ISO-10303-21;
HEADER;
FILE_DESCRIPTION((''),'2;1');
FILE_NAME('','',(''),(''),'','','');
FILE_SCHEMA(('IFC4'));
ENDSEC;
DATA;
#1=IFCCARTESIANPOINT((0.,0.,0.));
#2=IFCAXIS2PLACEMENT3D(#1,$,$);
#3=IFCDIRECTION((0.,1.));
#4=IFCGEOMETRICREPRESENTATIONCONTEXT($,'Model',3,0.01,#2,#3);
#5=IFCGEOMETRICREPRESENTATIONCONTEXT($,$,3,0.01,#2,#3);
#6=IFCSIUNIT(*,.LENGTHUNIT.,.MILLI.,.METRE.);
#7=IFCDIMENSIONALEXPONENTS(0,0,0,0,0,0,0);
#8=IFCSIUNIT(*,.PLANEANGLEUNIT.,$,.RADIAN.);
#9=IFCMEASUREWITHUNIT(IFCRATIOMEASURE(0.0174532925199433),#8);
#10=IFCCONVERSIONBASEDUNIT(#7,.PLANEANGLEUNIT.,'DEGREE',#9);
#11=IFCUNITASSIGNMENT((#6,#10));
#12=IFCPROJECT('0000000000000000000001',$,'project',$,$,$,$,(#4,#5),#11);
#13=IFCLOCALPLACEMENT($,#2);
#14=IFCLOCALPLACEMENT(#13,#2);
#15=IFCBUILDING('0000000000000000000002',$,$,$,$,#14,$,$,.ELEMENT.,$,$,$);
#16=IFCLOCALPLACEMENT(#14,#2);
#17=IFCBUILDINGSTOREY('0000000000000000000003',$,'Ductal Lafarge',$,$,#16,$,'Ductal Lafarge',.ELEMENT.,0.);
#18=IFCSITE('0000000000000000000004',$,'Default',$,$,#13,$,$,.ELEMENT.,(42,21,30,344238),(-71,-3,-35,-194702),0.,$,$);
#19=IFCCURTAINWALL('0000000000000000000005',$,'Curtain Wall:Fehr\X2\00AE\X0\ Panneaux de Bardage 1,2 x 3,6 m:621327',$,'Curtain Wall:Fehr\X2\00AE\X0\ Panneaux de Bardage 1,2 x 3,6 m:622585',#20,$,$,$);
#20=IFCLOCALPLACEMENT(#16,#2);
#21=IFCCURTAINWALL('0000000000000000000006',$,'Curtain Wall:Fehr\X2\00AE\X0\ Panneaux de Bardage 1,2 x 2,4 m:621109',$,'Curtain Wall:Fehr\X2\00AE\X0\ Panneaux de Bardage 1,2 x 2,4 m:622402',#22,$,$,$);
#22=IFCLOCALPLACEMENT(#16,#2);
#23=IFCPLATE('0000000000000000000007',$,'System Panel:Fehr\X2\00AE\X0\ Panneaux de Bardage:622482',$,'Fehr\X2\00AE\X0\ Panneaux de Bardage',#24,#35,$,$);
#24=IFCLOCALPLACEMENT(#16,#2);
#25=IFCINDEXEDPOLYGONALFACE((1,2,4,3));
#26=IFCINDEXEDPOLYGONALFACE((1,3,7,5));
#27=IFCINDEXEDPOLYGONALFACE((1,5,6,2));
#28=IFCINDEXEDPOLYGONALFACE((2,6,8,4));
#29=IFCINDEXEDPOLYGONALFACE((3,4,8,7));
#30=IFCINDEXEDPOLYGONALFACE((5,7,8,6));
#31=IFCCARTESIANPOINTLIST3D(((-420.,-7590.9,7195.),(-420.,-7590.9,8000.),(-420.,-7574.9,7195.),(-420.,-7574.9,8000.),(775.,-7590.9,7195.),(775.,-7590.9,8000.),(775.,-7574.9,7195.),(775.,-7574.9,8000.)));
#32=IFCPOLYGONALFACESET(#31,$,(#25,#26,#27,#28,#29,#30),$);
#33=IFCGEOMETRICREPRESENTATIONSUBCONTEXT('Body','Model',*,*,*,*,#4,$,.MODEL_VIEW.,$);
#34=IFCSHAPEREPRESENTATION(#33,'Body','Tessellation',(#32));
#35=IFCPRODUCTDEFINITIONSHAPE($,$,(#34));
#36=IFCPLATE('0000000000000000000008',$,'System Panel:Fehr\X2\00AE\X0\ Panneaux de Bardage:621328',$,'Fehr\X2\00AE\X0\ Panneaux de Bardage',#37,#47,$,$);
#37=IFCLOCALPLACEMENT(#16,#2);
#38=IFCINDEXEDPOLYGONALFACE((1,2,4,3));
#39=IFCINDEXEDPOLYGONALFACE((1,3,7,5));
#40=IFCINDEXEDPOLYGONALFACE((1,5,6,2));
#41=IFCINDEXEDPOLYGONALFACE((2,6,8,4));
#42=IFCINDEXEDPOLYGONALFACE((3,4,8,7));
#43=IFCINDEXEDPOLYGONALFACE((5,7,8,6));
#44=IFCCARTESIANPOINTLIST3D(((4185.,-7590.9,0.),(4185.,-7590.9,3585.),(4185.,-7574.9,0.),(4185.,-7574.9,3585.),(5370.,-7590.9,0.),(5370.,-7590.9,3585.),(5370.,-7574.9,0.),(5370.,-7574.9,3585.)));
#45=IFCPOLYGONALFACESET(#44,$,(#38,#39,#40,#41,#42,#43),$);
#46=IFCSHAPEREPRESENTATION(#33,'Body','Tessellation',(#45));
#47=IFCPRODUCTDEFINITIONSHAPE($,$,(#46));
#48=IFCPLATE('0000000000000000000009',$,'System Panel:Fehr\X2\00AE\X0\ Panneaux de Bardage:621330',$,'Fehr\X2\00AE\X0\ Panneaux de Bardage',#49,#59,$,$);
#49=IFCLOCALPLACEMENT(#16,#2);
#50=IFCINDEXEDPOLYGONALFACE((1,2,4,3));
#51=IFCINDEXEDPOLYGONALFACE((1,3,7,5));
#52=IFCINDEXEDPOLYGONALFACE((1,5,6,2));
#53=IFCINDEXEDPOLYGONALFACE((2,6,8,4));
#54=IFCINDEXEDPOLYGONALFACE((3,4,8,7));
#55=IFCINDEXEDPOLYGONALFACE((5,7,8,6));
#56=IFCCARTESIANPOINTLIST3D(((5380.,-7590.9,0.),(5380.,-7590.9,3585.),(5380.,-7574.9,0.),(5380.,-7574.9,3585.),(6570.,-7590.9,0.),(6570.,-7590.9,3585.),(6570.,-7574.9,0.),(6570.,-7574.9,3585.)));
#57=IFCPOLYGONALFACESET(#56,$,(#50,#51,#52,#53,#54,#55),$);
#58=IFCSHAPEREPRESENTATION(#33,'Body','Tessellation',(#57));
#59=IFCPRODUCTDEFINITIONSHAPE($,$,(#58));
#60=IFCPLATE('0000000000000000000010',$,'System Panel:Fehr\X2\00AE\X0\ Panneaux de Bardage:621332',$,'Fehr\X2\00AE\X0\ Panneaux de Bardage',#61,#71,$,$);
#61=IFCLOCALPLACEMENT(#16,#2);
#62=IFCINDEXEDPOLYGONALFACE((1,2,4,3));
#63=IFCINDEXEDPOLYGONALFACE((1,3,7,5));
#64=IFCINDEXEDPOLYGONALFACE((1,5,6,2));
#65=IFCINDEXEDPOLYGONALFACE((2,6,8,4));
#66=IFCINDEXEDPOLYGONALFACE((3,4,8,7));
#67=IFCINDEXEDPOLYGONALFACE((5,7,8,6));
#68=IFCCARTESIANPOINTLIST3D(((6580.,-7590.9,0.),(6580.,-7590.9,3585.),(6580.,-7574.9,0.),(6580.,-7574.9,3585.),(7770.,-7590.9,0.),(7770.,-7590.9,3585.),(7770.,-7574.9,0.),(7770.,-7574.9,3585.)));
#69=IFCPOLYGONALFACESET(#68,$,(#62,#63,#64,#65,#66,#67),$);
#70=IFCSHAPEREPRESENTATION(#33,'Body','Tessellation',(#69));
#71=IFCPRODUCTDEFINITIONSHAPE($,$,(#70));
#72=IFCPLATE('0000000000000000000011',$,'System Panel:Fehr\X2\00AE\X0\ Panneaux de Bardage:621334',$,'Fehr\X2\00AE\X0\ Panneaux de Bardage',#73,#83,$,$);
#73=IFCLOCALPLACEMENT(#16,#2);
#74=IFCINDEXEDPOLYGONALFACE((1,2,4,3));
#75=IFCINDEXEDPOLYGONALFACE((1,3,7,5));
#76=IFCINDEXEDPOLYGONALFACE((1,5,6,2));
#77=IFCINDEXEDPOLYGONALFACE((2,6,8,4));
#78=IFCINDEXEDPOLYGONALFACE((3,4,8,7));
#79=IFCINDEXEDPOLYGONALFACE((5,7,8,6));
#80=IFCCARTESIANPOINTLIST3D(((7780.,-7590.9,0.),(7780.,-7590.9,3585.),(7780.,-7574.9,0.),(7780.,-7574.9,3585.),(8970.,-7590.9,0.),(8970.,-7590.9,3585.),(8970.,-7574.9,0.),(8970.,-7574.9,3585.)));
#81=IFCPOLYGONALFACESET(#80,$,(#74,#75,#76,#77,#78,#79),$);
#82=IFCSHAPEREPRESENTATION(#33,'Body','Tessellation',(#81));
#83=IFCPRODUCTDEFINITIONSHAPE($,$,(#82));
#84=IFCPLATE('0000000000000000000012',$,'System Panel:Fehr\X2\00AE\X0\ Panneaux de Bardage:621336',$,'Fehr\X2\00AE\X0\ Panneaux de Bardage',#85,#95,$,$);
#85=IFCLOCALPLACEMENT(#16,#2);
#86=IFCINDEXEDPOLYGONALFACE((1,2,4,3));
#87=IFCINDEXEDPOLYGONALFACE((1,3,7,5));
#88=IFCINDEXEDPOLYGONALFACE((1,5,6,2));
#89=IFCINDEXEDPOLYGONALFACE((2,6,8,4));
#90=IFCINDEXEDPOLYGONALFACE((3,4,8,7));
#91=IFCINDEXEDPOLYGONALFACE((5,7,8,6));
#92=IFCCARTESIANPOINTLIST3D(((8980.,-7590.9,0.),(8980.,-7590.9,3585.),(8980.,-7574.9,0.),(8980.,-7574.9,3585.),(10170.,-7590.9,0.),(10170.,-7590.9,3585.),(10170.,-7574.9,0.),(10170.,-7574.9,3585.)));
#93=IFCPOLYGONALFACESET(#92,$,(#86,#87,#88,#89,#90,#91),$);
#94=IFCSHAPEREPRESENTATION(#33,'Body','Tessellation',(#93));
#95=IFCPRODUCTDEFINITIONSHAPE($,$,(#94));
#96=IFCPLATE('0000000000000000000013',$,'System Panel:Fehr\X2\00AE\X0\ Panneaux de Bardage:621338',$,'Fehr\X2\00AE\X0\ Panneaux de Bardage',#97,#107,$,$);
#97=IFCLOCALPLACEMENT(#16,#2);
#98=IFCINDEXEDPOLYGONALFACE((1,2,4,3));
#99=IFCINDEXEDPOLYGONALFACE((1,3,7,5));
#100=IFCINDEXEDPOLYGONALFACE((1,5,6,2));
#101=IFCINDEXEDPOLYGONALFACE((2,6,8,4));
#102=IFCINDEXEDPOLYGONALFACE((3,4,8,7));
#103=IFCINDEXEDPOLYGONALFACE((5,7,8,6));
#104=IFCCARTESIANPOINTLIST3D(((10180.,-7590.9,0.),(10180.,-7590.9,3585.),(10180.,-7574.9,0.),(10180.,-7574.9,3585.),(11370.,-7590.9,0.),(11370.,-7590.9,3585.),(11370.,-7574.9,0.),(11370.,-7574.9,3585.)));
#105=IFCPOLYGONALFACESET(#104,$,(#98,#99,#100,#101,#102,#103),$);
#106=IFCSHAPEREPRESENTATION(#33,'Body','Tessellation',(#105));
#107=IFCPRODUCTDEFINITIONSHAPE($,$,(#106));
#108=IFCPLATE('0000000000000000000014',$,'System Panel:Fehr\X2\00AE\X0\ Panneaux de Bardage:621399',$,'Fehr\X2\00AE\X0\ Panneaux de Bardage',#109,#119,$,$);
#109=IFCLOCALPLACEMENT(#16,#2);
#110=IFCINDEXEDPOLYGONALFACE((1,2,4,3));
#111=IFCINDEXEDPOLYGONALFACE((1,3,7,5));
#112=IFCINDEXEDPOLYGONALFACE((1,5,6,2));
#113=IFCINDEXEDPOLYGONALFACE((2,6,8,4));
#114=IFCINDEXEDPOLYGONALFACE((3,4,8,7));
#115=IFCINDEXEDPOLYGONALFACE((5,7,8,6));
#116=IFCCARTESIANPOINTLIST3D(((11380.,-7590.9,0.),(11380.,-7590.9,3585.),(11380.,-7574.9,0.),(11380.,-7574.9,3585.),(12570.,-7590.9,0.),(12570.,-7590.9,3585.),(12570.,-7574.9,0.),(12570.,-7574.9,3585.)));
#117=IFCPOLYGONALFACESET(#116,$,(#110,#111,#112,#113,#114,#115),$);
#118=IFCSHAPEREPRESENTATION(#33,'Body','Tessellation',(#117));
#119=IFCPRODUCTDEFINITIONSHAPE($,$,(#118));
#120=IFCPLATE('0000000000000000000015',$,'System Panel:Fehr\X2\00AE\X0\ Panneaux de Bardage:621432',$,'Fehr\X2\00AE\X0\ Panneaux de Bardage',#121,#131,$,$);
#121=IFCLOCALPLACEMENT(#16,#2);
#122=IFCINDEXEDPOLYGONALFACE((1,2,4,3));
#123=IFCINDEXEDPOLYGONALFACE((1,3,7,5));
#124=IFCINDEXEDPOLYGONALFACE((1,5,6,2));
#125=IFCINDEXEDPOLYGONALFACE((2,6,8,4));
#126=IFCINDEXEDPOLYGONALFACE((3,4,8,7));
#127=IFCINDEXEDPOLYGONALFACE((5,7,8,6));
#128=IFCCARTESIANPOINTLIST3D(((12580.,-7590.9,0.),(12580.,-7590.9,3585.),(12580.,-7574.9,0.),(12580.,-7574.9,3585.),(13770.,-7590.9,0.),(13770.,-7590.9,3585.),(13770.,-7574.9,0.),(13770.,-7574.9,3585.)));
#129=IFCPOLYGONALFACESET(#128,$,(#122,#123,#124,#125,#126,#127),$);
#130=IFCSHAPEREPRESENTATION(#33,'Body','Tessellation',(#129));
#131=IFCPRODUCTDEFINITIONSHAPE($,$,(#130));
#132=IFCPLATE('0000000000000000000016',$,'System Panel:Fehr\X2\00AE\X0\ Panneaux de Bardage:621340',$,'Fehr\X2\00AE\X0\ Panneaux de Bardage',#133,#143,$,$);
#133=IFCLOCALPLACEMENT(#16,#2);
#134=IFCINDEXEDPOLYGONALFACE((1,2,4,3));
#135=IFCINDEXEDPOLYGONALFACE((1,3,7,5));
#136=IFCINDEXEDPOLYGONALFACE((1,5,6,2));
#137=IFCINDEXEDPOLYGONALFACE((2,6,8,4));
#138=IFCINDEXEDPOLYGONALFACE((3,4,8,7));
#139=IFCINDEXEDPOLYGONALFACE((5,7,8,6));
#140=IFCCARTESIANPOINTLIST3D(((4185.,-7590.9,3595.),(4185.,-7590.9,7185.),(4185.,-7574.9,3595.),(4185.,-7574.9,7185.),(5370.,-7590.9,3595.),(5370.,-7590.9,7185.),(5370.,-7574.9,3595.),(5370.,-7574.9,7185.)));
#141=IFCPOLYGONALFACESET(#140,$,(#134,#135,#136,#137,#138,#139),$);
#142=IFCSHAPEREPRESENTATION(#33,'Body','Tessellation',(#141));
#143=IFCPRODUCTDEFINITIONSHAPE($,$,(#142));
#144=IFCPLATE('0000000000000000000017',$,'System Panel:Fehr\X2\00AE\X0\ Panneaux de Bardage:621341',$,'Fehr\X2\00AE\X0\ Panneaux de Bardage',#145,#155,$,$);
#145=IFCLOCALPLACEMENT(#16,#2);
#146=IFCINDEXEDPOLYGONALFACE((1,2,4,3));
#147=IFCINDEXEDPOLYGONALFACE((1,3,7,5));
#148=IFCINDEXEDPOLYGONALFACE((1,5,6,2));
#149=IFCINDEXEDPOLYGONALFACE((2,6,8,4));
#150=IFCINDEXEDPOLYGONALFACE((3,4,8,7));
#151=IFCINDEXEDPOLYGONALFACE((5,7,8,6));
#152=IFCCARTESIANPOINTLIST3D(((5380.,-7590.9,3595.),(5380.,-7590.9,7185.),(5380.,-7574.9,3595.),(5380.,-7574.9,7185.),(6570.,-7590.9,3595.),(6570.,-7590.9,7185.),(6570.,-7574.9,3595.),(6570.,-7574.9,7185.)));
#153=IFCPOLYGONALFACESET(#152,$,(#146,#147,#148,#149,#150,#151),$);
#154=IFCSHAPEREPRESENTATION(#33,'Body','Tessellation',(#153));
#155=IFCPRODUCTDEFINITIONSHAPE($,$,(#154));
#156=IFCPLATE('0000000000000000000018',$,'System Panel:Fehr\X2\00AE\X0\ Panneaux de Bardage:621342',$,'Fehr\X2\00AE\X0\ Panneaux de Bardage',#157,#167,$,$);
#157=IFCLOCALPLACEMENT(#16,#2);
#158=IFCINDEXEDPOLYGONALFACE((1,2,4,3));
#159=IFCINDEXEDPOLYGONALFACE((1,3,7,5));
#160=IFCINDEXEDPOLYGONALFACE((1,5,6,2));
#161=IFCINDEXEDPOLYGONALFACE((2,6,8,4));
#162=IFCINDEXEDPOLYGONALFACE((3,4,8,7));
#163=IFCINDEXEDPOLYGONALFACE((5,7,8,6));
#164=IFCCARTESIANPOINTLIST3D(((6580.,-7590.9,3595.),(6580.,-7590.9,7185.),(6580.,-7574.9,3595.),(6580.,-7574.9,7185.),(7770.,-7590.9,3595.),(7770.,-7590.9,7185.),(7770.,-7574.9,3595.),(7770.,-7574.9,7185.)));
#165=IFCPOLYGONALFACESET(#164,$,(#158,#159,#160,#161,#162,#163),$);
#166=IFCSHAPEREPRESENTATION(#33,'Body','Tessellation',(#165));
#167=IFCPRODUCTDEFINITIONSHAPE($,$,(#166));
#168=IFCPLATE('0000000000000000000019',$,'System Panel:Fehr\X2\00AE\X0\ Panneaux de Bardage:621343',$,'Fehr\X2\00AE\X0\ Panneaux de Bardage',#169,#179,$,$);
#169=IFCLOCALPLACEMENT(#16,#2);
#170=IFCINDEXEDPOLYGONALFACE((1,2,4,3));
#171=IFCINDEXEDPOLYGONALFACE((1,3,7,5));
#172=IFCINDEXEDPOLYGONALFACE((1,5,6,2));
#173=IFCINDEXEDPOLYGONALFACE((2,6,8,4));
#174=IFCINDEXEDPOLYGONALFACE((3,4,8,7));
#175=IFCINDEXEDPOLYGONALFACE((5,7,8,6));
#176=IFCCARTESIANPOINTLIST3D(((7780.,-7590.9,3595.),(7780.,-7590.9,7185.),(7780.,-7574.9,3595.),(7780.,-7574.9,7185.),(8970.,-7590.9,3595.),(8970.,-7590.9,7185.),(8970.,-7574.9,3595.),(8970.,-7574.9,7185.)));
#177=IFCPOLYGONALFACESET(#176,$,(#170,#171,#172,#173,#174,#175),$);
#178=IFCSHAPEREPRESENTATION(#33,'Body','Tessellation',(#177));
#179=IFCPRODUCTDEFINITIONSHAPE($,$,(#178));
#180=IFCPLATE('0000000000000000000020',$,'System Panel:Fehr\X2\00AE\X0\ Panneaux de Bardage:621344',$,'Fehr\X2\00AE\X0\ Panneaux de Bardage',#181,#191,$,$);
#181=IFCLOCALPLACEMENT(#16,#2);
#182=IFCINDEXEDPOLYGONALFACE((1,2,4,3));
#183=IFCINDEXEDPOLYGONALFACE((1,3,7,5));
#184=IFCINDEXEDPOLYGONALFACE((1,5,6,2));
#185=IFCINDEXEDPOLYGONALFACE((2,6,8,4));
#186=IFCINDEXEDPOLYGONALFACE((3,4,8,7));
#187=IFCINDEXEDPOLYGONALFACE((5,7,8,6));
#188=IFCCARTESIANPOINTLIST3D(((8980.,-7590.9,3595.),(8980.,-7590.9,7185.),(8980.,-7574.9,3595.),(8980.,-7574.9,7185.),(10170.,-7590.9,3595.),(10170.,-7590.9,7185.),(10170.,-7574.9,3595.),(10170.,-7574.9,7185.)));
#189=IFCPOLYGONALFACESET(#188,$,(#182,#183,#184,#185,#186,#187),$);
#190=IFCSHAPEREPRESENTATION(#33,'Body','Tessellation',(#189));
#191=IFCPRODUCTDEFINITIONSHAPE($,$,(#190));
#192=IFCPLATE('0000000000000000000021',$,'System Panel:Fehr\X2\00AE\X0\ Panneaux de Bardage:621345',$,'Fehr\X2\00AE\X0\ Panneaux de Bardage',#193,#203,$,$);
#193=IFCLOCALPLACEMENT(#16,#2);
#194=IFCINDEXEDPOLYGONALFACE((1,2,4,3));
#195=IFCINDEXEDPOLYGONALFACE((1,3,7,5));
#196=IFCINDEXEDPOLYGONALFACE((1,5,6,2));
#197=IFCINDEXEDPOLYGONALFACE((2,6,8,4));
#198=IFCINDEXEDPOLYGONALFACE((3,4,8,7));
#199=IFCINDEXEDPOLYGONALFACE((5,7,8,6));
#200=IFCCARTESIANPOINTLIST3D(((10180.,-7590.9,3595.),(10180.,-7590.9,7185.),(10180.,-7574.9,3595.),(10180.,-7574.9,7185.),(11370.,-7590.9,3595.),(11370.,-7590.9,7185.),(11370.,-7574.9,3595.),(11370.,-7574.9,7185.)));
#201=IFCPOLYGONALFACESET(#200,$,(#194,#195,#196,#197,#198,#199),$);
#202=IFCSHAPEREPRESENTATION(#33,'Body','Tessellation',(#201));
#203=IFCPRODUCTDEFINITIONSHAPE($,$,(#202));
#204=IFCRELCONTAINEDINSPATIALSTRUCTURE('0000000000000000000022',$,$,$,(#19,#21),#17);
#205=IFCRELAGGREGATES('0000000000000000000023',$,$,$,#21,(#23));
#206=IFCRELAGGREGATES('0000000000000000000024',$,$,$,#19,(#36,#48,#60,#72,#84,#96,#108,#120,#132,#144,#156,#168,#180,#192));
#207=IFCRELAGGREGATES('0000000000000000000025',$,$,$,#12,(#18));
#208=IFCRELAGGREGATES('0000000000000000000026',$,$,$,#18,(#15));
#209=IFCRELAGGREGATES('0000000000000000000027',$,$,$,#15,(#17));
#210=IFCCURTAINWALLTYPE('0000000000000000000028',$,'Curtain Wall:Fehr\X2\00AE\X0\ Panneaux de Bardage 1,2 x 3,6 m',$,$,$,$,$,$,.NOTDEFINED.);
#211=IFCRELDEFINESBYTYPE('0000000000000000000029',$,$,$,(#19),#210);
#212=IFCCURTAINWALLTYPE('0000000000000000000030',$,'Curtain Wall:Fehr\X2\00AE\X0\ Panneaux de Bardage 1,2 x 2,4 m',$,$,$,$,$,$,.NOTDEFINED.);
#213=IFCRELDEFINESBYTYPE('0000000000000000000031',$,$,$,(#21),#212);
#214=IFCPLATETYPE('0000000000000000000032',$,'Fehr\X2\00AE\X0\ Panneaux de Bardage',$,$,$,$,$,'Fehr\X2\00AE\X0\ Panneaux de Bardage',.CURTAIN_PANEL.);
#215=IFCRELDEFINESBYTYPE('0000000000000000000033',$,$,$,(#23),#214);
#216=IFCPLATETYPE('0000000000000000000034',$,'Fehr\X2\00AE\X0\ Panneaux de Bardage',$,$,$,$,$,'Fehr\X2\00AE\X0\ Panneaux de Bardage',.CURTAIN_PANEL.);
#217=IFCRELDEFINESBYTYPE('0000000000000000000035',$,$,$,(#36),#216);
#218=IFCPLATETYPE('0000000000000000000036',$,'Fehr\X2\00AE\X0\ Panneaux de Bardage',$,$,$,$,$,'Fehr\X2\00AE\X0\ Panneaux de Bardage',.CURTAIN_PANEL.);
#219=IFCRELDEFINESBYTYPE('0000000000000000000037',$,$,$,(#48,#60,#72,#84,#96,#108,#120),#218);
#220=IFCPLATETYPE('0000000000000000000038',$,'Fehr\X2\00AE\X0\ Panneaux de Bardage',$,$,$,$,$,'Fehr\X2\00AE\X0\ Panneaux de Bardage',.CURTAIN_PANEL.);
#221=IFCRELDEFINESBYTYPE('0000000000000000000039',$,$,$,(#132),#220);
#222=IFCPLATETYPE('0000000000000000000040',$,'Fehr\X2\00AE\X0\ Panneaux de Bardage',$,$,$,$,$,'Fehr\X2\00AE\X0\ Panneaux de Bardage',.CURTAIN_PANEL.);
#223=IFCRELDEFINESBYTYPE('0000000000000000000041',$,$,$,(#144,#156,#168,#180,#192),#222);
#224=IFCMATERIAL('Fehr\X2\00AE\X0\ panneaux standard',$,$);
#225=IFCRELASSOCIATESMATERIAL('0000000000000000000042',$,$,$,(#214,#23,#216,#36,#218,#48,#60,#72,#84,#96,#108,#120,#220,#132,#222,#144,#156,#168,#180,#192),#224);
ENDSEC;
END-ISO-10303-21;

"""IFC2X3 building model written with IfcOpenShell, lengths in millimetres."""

from ifc_helpers import new_model, entity, si_unit, converted_unit, direction, frame, origin, origin_2d_with_axis, place, context, subcontext, project, spatial, rectangle, extrude, source, transform, mapped, material, type_object, type_shapes, element, aggregate, save


model = new_model("IFC2X3")

# Units and contexts
model_context = context("Model", 3, precision=0.01, world=origin(), true_north=direction((0.0, 1.0)))
context_of_model = context(None, 3, precision=0.01, world=origin(), true_north=direction((0.0, 1.0)))
body_context = subcontext(model_context, "Body", "Model", "MODEL_VIEW")
ifc_project = project(units=[si_unit("LENGTHUNIT", "METRE", prefix="MILLI"), converted_unit("PLANEANGLEUNIT", "DEGREE", entity("IfcRatioMeasure", 0.0174532925199433), si_unit("PLANEANGLEUNIT", "RADIAN"), dimensions=[0, 0, 0, 0, 0, 0, 0])], contexts=[model_context, context_of_model])

# Site, building, storey
site_placement = place(None, origin())
site = spatial("IfcSite", under=ifc_project, at=site_placement, Name="Default", CompositionType="ELEMENT", RefLatitude=(42, 21, 30, 344238), RefLongitude=(-71, -3, -35, -194702), RefElevation=0.0)
building_placement = place(site_placement, origin())
building = spatial("IfcBuilding", under=site, at=building_placement, CompositionType="ELEMENT")
storey_placement = place(building_placement, origin())
storey = spatial("IfcBuildingStorey", under=building, at=storey_placement, Name="Ductal Lafarge", LongName="Ductal Lafarge", CompositionType="ELEMENT", Elevation=0.0)

# Curtain wall
curtain_wall_type_1 = type_object("IfcCurtainWallType", Name="Curtain Wall:Fehr® Panneaux de Bardage 1,2 x 3,6 m", PredefinedType="NOTDEFINED")
curtain_wall_1_placement = place(storey_placement, origin())
curtain_wall_1 = element("IfcCurtainWall", 1, at=curtain_wall_1_placement, inside=storey, type_object=curtain_wall_type_1, Name="Curtain Wall:Fehr® Panneaux de Bardage 1,2 x 3,6 m:621327", ObjectType="Curtain Wall:Fehr® Panneaux de Bardage 1,2 x 3,6 m:622585")
ifc_material_1 = material(Name="Fehr® panneaux standard")

# Curtain wall, plate
curtain_wall_type_2 = type_object("IfcCurtainWallType", Name="Curtain Wall:Fehr® Panneaux de Bardage 1,2 x 2,4 m", PredefinedType="NOTDEFINED")
curtain_wall_2_placement = place(storey_placement, origin())
curtain_wall_2 = element("IfcCurtainWall", 2, at=curtain_wall_2_placement, inside=storey, type_object=curtain_wall_type_2, Name="Curtain Wall:Fehr® Panneaux de Bardage 1,2 x 2,4 m:621109", ObjectType="Curtain Wall:Fehr® Panneaux de Bardage 1,2 x 2,4 m:622402")
plate_type_1 = type_object("IfcPlateType", Name="Fehr® Panneaux de Bardage", ElementType="Fehr® Panneaux de Bardage", PredefinedType="CURTAIN_PANEL", material=ifc_material_1)
shared_shape_1 = source(origin(), body_context, "Body", "SweptSolid", [
    extrude(rectangle(XDim=16.0, YDim=1195.0, at=origin_2d_with_axis()), frame((0.0, 0.0, 0.0), z_axis=(0.0, 0.0, 1.0), x_axis=(0.0, 1.0, 0.0)), (0.0, 0.0, 1.0), 805.0),
])
type_shapes(plate_type_1, [shared_shape_1])
plate_1_placement = place(curtain_wall_2_placement, frame((177.5, -7582.9, 7195.0)))
plate_1 = element("IfcPlate", 3, at=plate_1_placement, type_object=plate_type_1, material=ifc_material_1, Name="System Panel:Fehr® Panneaux de Bardage:622482", ObjectType="Fehr® Panneaux de Bardage", context=body_context, shape_type="MappedRepresentation", body=[
    mapped(shared_shape_1, transform((0.0, 0.0, 0.0), scale=1.0)),
])
aggregate(curtain_wall_2, [plate_1])

# Plates
plate_type_2 = type_object("IfcPlateType", Name="Fehr® Panneaux de Bardage", ElementType="Fehr® Panneaux de Bardage", PredefinedType="CURTAIN_PANEL", material=ifc_material_1)
shared_shape_2 = source(origin(), body_context, "Body", "SweptSolid", [
    extrude(rectangle(XDim=16.0, YDim=1185.0, at=origin_2d_with_axis()), frame((0.0, 0.0, 0.0), z_axis=(0.0, 0.0, 1.0), x_axis=(0.0, 1.0, 0.0)), (0.0, 0.0, 1.0), 3585.0),
])
type_shapes(plate_type_2, [shared_shape_2])
plate_2_placement = place(curtain_wall_1_placement, frame((4777.5, -7582.9, 0.0)))
plate_2 = element("IfcPlate", 4, at=plate_2_placement, type_object=plate_type_2, material=ifc_material_1, Name="System Panel:Fehr® Panneaux de Bardage:621328", ObjectType="Fehr® Panneaux de Bardage", context=body_context, shape_type="MappedRepresentation", body=[
    mapped(shared_shape_2, transform((0.0, 0.0, 0.0), scale=1.0)),
])
plate_type_3 = type_object("IfcPlateType", Name="Fehr® Panneaux de Bardage", ElementType="Fehr® Panneaux de Bardage", PredefinedType="CURTAIN_PANEL", material=ifc_material_1)
shared_shape_3 = source(origin(), body_context, "Body", "SweptSolid", [
    extrude(rectangle(XDim=16.0, YDim=1190.0, at=origin_2d_with_axis()), frame((0.0, 0.0, 0.0), z_axis=(0.0, 0.0, 1.0), x_axis=(0.0, 1.0, 0.0)), (0.0, 0.0, 1.0), 3585.0),
])
type_shapes(plate_type_3, [shared_shape_3])
plate_3_placement = place(curtain_wall_1_placement, frame((5975.0, -7582.9, 0.0)))
plate_3 = element("IfcPlate", 5, at=plate_3_placement, type_object=plate_type_3, material=ifc_material_1, Name="System Panel:Fehr® Panneaux de Bardage:621330", ObjectType="Fehr® Panneaux de Bardage", context=body_context, shape_type="MappedRepresentation", body=[
    mapped(shared_shape_3, transform((0.0, 0.0, 0.0), scale=1.0)),
])
plate_4_placement = place(curtain_wall_1_placement, frame((7175.0, -7582.9, 0.0)))
plate_4 = element("IfcPlate", 6, at=plate_4_placement, type_object=plate_type_3, material=ifc_material_1, Name="System Panel:Fehr® Panneaux de Bardage:621332", ObjectType="Fehr® Panneaux de Bardage", context=body_context, shape_type="MappedRepresentation", body=[
    mapped(shared_shape_3, transform((0.0, 0.0, 0.0), scale=1.0)),
])
plate_5_placement = place(curtain_wall_1_placement, frame((8375.0, -7582.9, 0.0)))
plate_5 = element("IfcPlate", 7, at=plate_5_placement, type_object=plate_type_3, material=ifc_material_1, Name="System Panel:Fehr® Panneaux de Bardage:621334", ObjectType="Fehr® Panneaux de Bardage", context=body_context, shape_type="MappedRepresentation", body=[
    mapped(shared_shape_3, transform((0.0, 0.0, 0.0), scale=1.0)),
])
plate_6_placement = place(curtain_wall_1_placement, frame((9575.0, -7582.9, 0.0)))
plate_6 = element("IfcPlate", 8, at=plate_6_placement, type_object=plate_type_3, material=ifc_material_1, Name="System Panel:Fehr® Panneaux de Bardage:621336", ObjectType="Fehr® Panneaux de Bardage", context=body_context, shape_type="MappedRepresentation", body=[
    mapped(shared_shape_3, transform((0.0, 0.0, 0.0), scale=1.0)),
])
plate_7_placement = place(curtain_wall_1_placement, frame((10775.0, -7582.9, 0.0)))
plate_7 = element("IfcPlate", 9, at=plate_7_placement, type_object=plate_type_3, material=ifc_material_1, Name="System Panel:Fehr® Panneaux de Bardage:621338", ObjectType="Fehr® Panneaux de Bardage", context=body_context, shape_type="MappedRepresentation", body=[
    mapped(shared_shape_3, transform((0.0, 0.0, 0.0), scale=1.0)),
])
plate_8_placement = place(curtain_wall_1_placement, frame((11975.0, -7582.9, 0.0)))
plate_8 = element("IfcPlate", 10, at=plate_8_placement, type_object=plate_type_3, material=ifc_material_1, Name="System Panel:Fehr® Panneaux de Bardage:621399", ObjectType="Fehr® Panneaux de Bardage", context=body_context, shape_type="MappedRepresentation", body=[
    mapped(shared_shape_3, transform((0.0, 0.0, 0.0), scale=1.0)),
])
plate_9_placement = place(curtain_wall_1_placement, frame((13175.0, -7582.9, 0.0)))
plate_9 = element("IfcPlate", 11, at=plate_9_placement, type_object=plate_type_3, material=ifc_material_1, Name="System Panel:Fehr® Panneaux de Bardage:621432", ObjectType="Fehr® Panneaux de Bardage", context=body_context, shape_type="MappedRepresentation", body=[
    mapped(shared_shape_3, transform((0.0, 0.0, 0.0), scale=1.0)),
])
plate_type_4 = type_object("IfcPlateType", Name="Fehr® Panneaux de Bardage", ElementType="Fehr® Panneaux de Bardage", PredefinedType="CURTAIN_PANEL", material=ifc_material_1)
shared_shape_4 = source(origin(), body_context, "Body", "SweptSolid", [
    extrude(rectangle(XDim=16.0, YDim=1185.0, at=origin_2d_with_axis()), frame((0.0, 0.0, 0.0), z_axis=(0.0, 0.0, 1.0), x_axis=(0.0, 1.0, 0.0)), (0.0, 0.0, 1.0), 3590.0),
])
type_shapes(plate_type_4, [shared_shape_4])
plate_10_placement = place(curtain_wall_1_placement, frame((4777.5, -7582.9, 3595.0)))
plate_10 = element("IfcPlate", 12, at=plate_10_placement, type_object=plate_type_4, material=ifc_material_1, Name="System Panel:Fehr® Panneaux de Bardage:621340", ObjectType="Fehr® Panneaux de Bardage", context=body_context, shape_type="MappedRepresentation", body=[
    mapped(shared_shape_4, transform((0.0, 0.0, 0.0), scale=1.0)),
])
plate_type_5 = type_object("IfcPlateType", Name="Fehr® Panneaux de Bardage", ElementType="Fehr® Panneaux de Bardage", PredefinedType="CURTAIN_PANEL", material=ifc_material_1)
shared_shape_5 = source(origin(), body_context, "Body", "SweptSolid", [
    extrude(rectangle(XDim=16.0, YDim=1190.0, at=origin_2d_with_axis()), frame((0.0, 0.0, 0.0), z_axis=(0.0, 0.0, 1.0), x_axis=(0.0, 1.0, 0.0)), (0.0, 0.0, 1.0), 3590.0),
])
type_shapes(plate_type_5, [shared_shape_5])
plate_11_placement = place(curtain_wall_1_placement, frame((5975.0, -7582.9, 3595.0)))
plate_11 = element("IfcPlate", 13, at=plate_11_placement, type_object=plate_type_5, material=ifc_material_1, Name="System Panel:Fehr® Panneaux de Bardage:621341", ObjectType="Fehr® Panneaux de Bardage", context=body_context, shape_type="MappedRepresentation", body=[
    mapped(shared_shape_5, transform((0.0, 0.0, 0.0), scale=1.0)),
])
plate_12_placement = place(curtain_wall_1_placement, frame((7175.0, -7582.9, 3595.0)))
plate_12 = element("IfcPlate", 14, at=plate_12_placement, type_object=plate_type_5, material=ifc_material_1, Name="System Panel:Fehr® Panneaux de Bardage:621342", ObjectType="Fehr® Panneaux de Bardage", context=body_context, shape_type="MappedRepresentation", body=[
    mapped(shared_shape_5, transform((0.0, 0.0, 0.0), scale=1.0)),
])
plate_13_placement = place(curtain_wall_1_placement, frame((8375.0, -7582.9, 3595.0)))
plate_13 = element("IfcPlate", 15, at=plate_13_placement, type_object=plate_type_5, material=ifc_material_1, Name="System Panel:Fehr® Panneaux de Bardage:621343", ObjectType="Fehr® Panneaux de Bardage", context=body_context, shape_type="MappedRepresentation", body=[
    mapped(shared_shape_5, transform((0.0, 0.0, 0.0), scale=1.0)),
])
plate_14_placement = place(curtain_wall_1_placement, frame((9575.0, -7582.9, 3595.0)))
plate_14 = element("IfcPlate", 16, at=plate_14_placement, type_object=plate_type_5, material=ifc_material_1, Name="System Panel:Fehr® Panneaux de Bardage:621344", ObjectType="Fehr® Panneaux de Bardage", context=body_context, shape_type="MappedRepresentation", body=[
    mapped(shared_shape_5, transform((0.0, 0.0, 0.0), scale=1.0)),
])
plate_15_placement = place(curtain_wall_1_placement, frame((10775.0, -7582.9, 3595.0)))
plate_15 = element("IfcPlate", 17, at=plate_15_placement, type_object=plate_type_5, material=ifc_material_1, Name="System Panel:Fehr® Panneaux de Bardage:621345", ObjectType="Fehr® Panneaux de Bardage", context=body_context, shape_type="MappedRepresentation", body=[
    mapped(shared_shape_5, transform((0.0, 0.0, 0.0), scale=1.0)),
])
aggregate(curtain_wall_1, [plate_2, plate_3, plate_4, plate_5, plate_6, plate_7, plate_8, plate_9, plate_10, plate_11, plate_12, plate_13, plate_14, plate_15])

save(model, "model.ifc")
